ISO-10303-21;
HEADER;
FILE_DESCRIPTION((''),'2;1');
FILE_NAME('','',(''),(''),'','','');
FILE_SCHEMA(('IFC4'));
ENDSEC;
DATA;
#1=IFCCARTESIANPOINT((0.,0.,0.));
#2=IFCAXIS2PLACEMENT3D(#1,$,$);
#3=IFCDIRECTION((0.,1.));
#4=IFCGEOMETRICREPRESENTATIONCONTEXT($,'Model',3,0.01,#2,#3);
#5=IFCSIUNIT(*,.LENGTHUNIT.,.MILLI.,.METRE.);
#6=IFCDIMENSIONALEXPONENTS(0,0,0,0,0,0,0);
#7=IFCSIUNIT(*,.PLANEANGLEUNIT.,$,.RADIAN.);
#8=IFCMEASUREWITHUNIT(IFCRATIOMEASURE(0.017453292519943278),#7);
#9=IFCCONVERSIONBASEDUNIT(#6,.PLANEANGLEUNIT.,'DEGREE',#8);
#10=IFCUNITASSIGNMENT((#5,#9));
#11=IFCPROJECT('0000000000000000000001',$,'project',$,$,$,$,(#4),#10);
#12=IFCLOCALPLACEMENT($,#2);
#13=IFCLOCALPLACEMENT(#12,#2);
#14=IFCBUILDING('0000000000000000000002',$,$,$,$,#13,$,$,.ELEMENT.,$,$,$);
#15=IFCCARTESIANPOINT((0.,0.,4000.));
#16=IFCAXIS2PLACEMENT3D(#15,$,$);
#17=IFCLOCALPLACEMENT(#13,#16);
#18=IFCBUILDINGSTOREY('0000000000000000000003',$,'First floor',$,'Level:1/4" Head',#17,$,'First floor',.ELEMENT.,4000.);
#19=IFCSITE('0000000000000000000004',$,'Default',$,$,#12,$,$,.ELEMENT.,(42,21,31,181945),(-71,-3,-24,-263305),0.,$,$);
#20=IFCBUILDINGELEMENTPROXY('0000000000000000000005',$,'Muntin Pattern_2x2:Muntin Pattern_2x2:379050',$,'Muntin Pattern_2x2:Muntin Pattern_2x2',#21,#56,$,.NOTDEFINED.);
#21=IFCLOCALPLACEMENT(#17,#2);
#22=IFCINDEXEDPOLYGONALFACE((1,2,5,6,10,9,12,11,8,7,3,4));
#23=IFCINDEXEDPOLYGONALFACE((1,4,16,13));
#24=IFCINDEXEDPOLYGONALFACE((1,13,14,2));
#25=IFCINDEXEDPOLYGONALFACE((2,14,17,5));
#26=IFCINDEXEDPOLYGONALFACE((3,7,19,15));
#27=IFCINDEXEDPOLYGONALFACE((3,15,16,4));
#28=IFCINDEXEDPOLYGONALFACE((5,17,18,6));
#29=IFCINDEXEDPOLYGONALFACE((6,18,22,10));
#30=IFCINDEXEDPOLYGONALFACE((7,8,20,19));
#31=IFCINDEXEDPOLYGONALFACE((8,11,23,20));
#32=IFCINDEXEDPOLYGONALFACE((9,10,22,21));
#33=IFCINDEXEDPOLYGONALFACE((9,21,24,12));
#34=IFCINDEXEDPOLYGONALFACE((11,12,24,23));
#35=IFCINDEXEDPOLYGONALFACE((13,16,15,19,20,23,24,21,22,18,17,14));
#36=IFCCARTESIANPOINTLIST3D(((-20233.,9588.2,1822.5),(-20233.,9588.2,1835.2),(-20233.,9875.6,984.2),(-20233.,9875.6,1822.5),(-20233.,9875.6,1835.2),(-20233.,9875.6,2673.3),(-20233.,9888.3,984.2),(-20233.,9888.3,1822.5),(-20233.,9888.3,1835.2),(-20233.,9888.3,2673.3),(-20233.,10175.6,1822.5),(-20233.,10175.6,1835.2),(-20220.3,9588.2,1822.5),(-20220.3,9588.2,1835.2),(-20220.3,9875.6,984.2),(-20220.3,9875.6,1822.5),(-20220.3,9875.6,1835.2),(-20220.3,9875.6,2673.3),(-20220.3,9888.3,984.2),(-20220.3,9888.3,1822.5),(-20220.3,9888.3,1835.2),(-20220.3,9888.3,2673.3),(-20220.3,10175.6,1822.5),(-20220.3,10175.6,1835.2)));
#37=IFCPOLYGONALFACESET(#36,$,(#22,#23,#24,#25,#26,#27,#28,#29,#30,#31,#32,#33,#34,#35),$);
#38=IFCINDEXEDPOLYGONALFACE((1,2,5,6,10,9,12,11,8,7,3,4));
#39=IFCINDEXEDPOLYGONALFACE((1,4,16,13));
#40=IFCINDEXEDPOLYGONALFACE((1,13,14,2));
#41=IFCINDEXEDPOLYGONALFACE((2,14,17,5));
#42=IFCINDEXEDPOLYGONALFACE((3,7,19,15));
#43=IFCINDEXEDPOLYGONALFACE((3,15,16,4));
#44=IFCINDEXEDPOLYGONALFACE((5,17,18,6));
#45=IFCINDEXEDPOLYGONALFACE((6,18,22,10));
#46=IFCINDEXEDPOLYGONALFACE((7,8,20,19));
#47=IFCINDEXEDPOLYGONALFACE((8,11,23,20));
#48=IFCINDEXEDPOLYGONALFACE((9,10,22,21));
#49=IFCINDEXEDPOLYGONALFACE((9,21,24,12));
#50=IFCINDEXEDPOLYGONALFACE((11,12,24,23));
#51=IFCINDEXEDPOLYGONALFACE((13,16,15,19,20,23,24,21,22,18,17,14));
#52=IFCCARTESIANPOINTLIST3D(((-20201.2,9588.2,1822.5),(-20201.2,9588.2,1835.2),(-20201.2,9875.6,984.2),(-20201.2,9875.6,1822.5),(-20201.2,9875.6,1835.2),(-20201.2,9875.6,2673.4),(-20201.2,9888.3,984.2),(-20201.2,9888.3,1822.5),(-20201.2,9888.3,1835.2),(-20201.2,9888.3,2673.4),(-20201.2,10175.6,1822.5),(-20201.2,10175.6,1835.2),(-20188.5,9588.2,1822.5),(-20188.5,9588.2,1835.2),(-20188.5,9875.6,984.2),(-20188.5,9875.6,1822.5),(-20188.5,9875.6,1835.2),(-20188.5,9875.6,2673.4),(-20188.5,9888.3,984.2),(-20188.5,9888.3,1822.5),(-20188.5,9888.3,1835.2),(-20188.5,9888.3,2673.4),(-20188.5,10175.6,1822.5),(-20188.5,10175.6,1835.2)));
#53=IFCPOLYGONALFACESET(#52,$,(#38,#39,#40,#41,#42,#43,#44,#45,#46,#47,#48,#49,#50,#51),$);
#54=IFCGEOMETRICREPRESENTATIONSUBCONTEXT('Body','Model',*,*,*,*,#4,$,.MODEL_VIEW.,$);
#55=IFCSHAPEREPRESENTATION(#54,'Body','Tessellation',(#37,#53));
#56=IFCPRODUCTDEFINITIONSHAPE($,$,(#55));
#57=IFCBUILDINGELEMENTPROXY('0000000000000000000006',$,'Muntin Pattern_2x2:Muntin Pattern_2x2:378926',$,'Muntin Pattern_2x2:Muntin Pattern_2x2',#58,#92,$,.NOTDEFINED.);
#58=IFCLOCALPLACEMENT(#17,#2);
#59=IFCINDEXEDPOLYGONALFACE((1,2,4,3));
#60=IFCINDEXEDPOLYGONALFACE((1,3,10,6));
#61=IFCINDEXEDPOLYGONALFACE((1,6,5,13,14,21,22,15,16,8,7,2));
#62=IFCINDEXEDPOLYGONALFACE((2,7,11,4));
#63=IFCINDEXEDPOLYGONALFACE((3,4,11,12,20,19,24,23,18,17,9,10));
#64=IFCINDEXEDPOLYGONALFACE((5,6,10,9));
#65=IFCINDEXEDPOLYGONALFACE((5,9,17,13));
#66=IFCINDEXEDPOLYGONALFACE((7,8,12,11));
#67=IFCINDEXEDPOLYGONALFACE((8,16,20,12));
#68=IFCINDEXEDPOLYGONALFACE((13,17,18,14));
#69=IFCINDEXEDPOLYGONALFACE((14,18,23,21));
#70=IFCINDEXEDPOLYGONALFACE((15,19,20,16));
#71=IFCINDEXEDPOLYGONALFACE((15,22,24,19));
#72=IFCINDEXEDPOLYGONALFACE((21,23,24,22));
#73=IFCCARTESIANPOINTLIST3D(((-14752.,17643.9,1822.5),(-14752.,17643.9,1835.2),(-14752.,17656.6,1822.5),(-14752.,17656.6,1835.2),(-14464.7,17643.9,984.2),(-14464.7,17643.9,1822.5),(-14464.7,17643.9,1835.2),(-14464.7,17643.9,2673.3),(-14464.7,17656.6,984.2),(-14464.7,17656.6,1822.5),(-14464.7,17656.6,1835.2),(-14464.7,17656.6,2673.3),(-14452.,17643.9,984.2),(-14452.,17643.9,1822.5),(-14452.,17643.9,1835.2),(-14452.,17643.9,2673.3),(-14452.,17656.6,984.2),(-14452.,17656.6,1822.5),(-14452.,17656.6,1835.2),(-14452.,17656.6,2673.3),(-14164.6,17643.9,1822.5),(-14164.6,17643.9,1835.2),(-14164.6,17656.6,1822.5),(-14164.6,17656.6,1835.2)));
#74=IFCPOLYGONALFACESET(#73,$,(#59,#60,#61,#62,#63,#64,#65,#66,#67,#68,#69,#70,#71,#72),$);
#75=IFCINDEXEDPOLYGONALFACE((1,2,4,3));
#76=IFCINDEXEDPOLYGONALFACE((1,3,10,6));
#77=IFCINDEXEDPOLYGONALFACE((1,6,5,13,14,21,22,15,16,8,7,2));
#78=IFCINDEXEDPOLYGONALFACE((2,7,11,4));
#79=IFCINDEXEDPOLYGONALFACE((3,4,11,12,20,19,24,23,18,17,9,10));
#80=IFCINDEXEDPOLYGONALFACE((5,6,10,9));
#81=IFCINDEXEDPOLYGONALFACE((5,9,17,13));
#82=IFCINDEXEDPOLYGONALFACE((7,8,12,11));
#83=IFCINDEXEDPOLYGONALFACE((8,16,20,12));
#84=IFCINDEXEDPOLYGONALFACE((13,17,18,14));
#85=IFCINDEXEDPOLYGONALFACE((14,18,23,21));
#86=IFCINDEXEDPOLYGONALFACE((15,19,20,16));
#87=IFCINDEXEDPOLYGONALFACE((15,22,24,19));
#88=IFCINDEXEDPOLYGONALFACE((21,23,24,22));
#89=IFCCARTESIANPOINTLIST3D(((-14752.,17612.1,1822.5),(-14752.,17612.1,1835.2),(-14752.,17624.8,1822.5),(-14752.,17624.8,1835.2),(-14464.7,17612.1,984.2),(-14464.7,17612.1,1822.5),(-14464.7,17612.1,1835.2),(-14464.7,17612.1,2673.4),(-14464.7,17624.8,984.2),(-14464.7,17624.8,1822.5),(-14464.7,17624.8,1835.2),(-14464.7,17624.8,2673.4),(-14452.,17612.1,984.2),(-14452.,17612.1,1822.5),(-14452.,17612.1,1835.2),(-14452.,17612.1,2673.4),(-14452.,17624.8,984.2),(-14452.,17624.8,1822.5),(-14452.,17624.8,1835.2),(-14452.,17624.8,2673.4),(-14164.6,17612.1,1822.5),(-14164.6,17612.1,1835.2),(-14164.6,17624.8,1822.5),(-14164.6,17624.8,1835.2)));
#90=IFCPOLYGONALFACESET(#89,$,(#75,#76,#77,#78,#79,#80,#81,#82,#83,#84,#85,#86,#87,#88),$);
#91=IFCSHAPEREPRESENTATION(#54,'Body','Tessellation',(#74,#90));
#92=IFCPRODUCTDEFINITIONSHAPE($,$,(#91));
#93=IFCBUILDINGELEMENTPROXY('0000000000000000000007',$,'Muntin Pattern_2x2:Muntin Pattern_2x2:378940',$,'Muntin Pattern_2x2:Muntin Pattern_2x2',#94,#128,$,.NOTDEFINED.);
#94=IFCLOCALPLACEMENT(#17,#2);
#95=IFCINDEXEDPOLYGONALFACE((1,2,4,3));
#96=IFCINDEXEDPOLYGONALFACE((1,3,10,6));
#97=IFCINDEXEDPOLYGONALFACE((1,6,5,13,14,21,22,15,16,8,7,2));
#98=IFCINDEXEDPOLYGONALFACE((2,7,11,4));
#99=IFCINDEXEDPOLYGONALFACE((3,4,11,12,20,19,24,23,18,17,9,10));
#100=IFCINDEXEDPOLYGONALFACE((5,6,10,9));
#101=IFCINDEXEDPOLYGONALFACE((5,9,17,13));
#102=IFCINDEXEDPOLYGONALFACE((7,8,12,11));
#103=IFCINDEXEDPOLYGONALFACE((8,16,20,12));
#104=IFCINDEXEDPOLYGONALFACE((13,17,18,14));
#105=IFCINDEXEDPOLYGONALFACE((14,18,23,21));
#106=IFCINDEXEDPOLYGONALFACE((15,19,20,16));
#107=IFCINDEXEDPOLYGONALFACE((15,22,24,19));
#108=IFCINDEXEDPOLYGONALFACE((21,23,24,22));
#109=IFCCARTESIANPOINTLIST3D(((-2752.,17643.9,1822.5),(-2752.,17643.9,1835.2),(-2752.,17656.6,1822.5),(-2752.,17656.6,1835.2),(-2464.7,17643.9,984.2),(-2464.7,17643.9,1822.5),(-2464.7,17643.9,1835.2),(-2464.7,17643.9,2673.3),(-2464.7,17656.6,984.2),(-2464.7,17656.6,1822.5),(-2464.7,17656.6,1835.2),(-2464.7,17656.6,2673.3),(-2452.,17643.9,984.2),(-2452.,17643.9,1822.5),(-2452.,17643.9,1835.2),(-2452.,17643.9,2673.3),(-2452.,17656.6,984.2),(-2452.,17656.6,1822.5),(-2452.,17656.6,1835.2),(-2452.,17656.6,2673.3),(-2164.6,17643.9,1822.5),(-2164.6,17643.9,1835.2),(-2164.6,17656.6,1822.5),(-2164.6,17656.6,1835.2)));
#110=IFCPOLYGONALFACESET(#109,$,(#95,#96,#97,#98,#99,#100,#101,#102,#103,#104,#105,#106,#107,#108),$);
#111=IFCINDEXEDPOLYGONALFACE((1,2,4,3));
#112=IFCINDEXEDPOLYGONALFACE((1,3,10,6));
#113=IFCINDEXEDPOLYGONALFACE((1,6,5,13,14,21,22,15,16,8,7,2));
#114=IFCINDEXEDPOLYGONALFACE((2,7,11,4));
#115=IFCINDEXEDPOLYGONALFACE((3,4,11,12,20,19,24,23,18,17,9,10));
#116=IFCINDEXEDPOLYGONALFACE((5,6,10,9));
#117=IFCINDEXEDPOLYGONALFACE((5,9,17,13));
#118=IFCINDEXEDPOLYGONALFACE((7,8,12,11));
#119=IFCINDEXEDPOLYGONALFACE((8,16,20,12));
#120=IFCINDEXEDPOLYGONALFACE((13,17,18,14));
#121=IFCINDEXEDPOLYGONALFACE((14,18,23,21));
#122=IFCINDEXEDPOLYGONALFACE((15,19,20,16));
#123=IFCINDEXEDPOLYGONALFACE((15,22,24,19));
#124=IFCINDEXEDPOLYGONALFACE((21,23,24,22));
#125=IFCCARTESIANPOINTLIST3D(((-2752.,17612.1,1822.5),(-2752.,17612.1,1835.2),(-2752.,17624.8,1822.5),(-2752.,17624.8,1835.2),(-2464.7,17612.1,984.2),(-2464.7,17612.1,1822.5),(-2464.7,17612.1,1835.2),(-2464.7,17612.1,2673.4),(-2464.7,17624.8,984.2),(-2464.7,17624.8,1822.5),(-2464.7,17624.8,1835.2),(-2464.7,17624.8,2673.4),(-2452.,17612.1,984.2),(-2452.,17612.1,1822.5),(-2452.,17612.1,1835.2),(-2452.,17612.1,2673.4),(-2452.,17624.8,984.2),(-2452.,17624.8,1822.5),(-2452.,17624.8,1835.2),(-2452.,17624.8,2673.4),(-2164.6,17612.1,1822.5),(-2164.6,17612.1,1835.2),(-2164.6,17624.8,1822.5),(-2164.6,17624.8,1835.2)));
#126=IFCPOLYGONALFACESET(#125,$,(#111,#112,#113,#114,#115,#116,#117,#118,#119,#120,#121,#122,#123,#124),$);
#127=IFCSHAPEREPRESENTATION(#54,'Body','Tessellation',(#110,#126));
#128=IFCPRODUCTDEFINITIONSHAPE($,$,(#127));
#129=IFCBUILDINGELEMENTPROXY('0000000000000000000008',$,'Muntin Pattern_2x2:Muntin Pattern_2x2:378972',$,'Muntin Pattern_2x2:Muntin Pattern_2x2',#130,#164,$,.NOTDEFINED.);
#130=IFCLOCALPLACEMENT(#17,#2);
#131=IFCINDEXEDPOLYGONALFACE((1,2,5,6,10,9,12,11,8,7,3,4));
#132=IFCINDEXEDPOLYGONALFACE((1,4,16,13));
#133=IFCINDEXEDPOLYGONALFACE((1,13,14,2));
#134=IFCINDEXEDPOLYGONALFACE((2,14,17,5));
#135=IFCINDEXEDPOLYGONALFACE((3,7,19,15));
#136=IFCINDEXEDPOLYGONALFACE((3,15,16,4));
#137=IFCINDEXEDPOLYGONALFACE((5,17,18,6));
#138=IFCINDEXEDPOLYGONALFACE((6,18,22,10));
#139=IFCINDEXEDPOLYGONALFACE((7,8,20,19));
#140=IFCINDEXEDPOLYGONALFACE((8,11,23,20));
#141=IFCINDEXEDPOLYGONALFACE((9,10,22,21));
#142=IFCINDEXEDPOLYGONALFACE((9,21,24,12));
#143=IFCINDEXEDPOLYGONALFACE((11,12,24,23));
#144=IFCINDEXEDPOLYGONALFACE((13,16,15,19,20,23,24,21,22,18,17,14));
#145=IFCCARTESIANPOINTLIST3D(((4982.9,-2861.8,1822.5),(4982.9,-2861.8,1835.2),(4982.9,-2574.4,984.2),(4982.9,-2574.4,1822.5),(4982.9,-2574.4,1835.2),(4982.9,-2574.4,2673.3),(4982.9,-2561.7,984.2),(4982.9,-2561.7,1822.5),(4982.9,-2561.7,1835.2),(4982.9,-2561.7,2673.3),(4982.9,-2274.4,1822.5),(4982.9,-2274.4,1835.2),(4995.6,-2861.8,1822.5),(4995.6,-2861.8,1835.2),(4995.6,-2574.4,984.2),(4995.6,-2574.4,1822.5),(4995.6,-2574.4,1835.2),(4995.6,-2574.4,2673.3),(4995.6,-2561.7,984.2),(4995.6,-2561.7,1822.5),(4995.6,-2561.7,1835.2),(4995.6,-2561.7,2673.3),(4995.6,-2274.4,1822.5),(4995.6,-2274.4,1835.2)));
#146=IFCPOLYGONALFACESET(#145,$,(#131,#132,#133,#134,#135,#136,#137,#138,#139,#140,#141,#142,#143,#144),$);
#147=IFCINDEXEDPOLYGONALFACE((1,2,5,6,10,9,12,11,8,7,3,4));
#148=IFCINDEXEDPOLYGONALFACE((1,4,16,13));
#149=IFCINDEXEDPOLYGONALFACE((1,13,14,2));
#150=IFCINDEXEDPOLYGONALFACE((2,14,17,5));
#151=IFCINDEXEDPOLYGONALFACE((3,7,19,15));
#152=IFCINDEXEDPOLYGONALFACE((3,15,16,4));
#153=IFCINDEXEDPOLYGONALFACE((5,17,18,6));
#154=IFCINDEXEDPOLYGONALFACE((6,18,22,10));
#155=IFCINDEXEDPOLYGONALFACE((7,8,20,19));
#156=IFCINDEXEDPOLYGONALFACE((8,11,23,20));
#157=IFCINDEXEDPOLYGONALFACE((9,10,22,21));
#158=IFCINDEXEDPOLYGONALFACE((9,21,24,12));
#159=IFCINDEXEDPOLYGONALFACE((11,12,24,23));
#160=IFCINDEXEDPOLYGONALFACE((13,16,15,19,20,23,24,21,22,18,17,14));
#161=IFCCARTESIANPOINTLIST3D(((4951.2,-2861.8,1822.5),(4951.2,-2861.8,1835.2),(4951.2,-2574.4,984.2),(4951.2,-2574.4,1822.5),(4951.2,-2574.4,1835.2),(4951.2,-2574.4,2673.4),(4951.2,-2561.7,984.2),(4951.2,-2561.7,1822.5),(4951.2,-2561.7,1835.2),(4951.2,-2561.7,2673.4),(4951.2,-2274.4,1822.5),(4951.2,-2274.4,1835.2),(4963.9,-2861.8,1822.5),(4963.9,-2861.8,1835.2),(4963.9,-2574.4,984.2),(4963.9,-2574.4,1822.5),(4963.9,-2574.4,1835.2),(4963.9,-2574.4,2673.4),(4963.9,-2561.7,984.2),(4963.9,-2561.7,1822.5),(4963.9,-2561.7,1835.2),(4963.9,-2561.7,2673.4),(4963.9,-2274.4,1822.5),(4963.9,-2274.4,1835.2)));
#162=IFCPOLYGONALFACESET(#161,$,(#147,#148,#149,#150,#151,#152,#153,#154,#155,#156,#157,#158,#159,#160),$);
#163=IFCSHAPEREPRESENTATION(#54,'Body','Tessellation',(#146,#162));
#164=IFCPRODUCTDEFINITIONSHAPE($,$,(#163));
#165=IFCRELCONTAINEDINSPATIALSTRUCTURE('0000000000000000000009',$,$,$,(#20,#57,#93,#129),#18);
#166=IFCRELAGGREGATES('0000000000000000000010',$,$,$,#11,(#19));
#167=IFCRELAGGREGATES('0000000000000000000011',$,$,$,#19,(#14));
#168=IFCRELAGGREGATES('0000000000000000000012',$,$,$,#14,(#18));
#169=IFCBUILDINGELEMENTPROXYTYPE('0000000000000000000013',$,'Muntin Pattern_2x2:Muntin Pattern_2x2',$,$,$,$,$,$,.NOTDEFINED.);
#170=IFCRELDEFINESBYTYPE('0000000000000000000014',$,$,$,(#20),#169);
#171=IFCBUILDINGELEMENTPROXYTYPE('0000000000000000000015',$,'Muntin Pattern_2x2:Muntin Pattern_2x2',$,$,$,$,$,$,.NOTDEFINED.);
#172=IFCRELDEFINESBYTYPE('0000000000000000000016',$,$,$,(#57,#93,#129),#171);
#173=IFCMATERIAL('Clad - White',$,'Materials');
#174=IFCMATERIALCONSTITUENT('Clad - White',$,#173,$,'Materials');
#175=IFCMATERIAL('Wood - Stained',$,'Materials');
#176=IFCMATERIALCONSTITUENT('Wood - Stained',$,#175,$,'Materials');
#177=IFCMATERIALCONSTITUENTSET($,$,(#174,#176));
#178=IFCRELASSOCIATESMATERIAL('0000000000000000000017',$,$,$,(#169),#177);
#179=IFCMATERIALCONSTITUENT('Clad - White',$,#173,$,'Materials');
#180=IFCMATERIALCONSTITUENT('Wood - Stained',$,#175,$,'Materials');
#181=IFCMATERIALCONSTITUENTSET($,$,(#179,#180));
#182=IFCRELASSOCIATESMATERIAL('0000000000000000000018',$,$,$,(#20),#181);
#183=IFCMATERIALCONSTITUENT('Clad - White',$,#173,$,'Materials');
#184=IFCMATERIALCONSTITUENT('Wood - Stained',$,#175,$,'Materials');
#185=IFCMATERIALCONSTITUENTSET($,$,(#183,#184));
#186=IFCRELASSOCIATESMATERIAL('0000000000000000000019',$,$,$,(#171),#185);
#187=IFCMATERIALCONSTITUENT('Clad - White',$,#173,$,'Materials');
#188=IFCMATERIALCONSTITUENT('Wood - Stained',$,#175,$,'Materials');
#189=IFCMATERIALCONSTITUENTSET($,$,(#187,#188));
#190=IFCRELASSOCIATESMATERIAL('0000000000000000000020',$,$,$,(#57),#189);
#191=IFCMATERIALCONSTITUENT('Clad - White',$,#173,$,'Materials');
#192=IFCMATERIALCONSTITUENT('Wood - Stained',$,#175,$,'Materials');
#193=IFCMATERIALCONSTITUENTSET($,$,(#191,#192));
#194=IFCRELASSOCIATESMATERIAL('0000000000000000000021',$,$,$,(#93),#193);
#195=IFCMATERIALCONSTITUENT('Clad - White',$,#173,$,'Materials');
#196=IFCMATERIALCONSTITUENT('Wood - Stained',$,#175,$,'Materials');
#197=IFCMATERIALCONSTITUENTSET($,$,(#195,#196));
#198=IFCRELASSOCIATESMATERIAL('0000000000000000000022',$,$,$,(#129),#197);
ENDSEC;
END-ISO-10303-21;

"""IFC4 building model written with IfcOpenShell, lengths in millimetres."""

from ifc_helpers import new_model, entity, si_unit, converted_unit, direction, frame, origin, place, context, subcontext, project, spatial, indexed_curve, outline, extrude, source, transform, mapped, material, constituent, constituent_set, type_object, type_shapes, element, save


model = new_model("IFC4")

# Units and contexts
model_context = context("Model", 3, precision=0.01, world=origin(), true_north=direction((0.0, 1.0)))
body_context = subcontext(model_context, "Body", "Model", "MODEL_VIEW")
ifc_project = project(units=[si_unit("LENGTHUNIT", "METRE", prefix="MILLI"), converted_unit("PLANEANGLEUNIT", "DEGREE", entity("IfcRatioMeasure", 0.017453292519943278), si_unit("PLANEANGLEUNIT", "RADIAN"), dimensions=[0, 0, 0, 0, 0, 0, 0])], contexts=[model_context])

# Site, building, storey
site_placement = place(None, origin())
site = spatial("IfcSite", under=ifc_project, at=site_placement, Name="Default", CompositionType="ELEMENT", RefLatitude=(42, 21, 31, 181945), RefLongitude=(-71, -3, -24, -263305), RefElevation=0.0)
building_placement = place(site_placement, origin())
building = spatial("IfcBuilding", under=site, at=building_placement, CompositionType="ELEMENT")
storey_placement = place(building_placement, frame((0.0, 0.0, 4000.0)))
storey = spatial("IfcBuildingStorey", under=building, at=storey_placement, Name="First floor", ObjectType="Level:1/4\" Head", LongName="First floor", CompositionType="ELEMENT", Elevation=4000.0)

# Building element proxies
ifc_material_1 = material(Name="Clad - White", Category="Materials")
ifc_material_2 = material(Name="Wood - Stained", Category="Materials")
ifc_constituent_1 = constituent(ifc_material_1, Name="Clad - White", Category="Materials")
ifc_constituent_2 = constituent(ifc_material_2, Name="Wood - Stained", Category="Materials")
ifc_constituent_set_1 = constituent_set(constituents=[ifc_constituent_1, ifc_constituent_2])
building_element_proxy_type_1 = type_object("IfcBuildingElementProxyType", Name="Muntin Pattern_2x2:Muntin Pattern_2x2", PredefinedType="NOTDEFINED", material=ifc_constituent_set_1)
shared_shape_1 = source(origin(), body_context, "Body", "SweptSolid", [
    extrude(outline(indexed_curve([(6.4, -6.4), (844.5, -6.4), (844.5, 6.3), (6.4, 6.3), (6.4, 293.7), (-6.3, 293.7), (-6.3, 6.3), (-844.6, 6.3), (-844.6, -6.4), (-6.3, -6.4), (-6.3, -293.7), (6.4, -293.7), (6.4, -6.4)], self_intersect=False)), frame((0.0, 9.5, 844.5), z_axis=(0.0, 1.0, 0.0), x_axis=(0.0, 0.0, 1.0)), (0.0, 0.0, 1.0), 12.7),
    extrude(outline(indexed_curve([(6.4, -6.4), (844.6, -6.4), (844.6, 6.3), (6.4, 6.3), (6.4, 293.7), (-6.3, 293.7), (-6.3, 6.3), (-844.6, 6.3), (-844.6, -6.4), (-6.3, -6.4), (-6.3, -293.7), (6.4, -293.7), (6.4, -6.4)], self_intersect=False)), frame((0.0, -22.2, 844.6), z_axis=(0.0, 1.0, 0.0), x_axis=(0.0, 0.0, 1.0)), (0.0, 0.0, 1.0), 12.7),
])
type_shapes(building_element_proxy_type_1, [shared_shape_1])
ifc_constituent_3 = constituent(ifc_material_1, Name="Clad - White", Category="Materials")
ifc_constituent_4 = constituent(ifc_material_2, Name="Wood - Stained", Category="Materials")
ifc_constituent_set_2 = constituent_set(constituents=[ifc_constituent_3, ifc_constituent_4])
proxy_1_placement = place(storey_placement, frame((-20210.8, 9881.9, 984.3), z_axis=(0.0, 0.0, 1.0), x_axis=(0.0, 1.0, 0.0)))
element("IfcBuildingElementProxy", 1, at=proxy_1_placement, inside=storey, type_object=building_element_proxy_type_1, material=ifc_constituent_set_2, Name="Muntin Pattern_2x2:Muntin Pattern_2x2:379050", ObjectType="Muntin Pattern_2x2:Muntin Pattern_2x2", PredefinedType="NOTDEFINED", context=body_context, shape_type="MappedRepresentation", body=[
    mapped(shared_shape_1, transform((0.0, 0.0, 0.0), scale=1.0)),
])
ifc_constituent_5 = constituent(ifc_material_1, Name="Clad - White", Category="Materials")
ifc_constituent_6 = constituent(ifc_material_2, Name="Wood - Stained", Category="Materials")
ifc_constituent_set_3 = constituent_set(constituents=[ifc_constituent_5, ifc_constituent_6])
ifc_constituent_7 = constituent(ifc_material_1, Name="Clad - White", Category="Materials")
ifc_constituent_8 = constituent(ifc_material_2, Name="Wood - Stained", Category="Materials")
ifc_constituent_set_4 = constituent_set(constituents=[ifc_constituent_7, ifc_constituent_8])
building_element_proxy_type_2 = type_object("IfcBuildingElementProxyType", Name="Muntin Pattern_2x2:Muntin Pattern_2x2", PredefinedType="NOTDEFINED", material=ifc_constituent_set_4)
shared_shape_2 = source(origin(), body_context, "Body", "SweptSolid", [
    extrude(outline(indexed_curve([(6.4, -6.4), (844.5, -6.4), (844.5, 6.3), (6.4, 6.3), (6.4, 293.7), (-6.3, 293.7), (-6.3, 6.3), (-844.6, 6.3), (-844.6, -6.4), (-6.3, -6.4), (-6.3, -293.7), (6.4, -293.7), (6.4, -6.4)], self_intersect=False)), frame((0.0, -22.2, 844.5), z_axis=(0.0, 1.0, 0.0), x_axis=(0.0, 0.0, 1.0)), (0.0, 0.0, 1.0), 12.7),
    extrude(outline(indexed_curve([(6.4, -6.4), (844.6, -6.4), (844.6, 6.3), (6.4, 6.3), (6.4, 293.7), (-6.3, 293.7), (-6.3, 6.3), (-844.6, 6.3), (-844.6, -6.4), (-6.3, -6.4), (-6.3, -293.7), (6.4, -293.7), (6.4, -6.4)], self_intersect=False)), frame((0.0, 9.5, 844.6), z_axis=(0.0, 1.0, 0.0), x_axis=(0.0, 0.0, 1.0)), (0.0, 0.0, 1.0), 12.7),
])
type_shapes(building_element_proxy_type_2, [shared_shape_2])
proxy_2_placement = place(storey_placement, frame((-14458.3, 17634.3, 984.3), z_axis=(0.0, 0.0, 1.0), x_axis=(-1.0, 0.0, 0.0)))
element("IfcBuildingElementProxy", 2, at=proxy_2_placement, inside=storey, type_object=building_element_proxy_type_2, material=ifc_constituent_set_3, Name="Muntin Pattern_2x2:Muntin Pattern_2x2:378926", ObjectType="Muntin Pattern_2x2:Muntin Pattern_2x2", PredefinedType="NOTDEFINED", context=body_context, shape_type="MappedRepresentation", body=[
    mapped(shared_shape_2, transform((0.0, 0.0, 0.0), scale=1.0)),
])
ifc_constituent_9 = constituent(ifc_material_1, Name="Clad - White", Category="Materials")
ifc_constituent_10 = constituent(ifc_material_2, Name="Wood - Stained", Category="Materials")
ifc_constituent_set_5 = constituent_set(constituents=[ifc_constituent_9, ifc_constituent_10])
proxy_3_placement = place(storey_placement, frame((-2458.3, 17634.3, 984.3), z_axis=(0.0, 0.0, 1.0), x_axis=(-1.0, 0.0, 0.0)))
element("IfcBuildingElementProxy", 3, at=proxy_3_placement, inside=storey, type_object=building_element_proxy_type_2, material=ifc_constituent_set_5, Name="Muntin Pattern_2x2:Muntin Pattern_2x2:378940", ObjectType="Muntin Pattern_2x2:Muntin Pattern_2x2", PredefinedType="NOTDEFINED", context=body_context, shape_type="MappedRepresentation", body=[
    mapped(shared_shape_2, transform((0.0, 0.0, 0.0), scale=1.0)),
])
ifc_constituent_11 = constituent(ifc_material_1, Name="Clad - White", Category="Materials")
ifc_constituent_12 = constituent(ifc_material_2, Name="Wood - Stained", Category="Materials")
ifc_constituent_set_6 = constituent_set(constituents=[ifc_constituent_11, ifc_constituent_12])
proxy_4_placement = place(storey_placement, frame((4973.4, -2568.1, 984.3), z_axis=(0.0, 0.0, 1.0), x_axis=(0.0, 1.0, 0.0)))
element("IfcBuildingElementProxy", 4, at=proxy_4_placement, inside=storey, type_object=building_element_proxy_type_2, material=ifc_constituent_set_6, Name="Muntin Pattern_2x2:Muntin Pattern_2x2:378972", ObjectType="Muntin Pattern_2x2:Muntin Pattern_2x2", PredefinedType="NOTDEFINED", context=body_context, shape_type="MappedRepresentation", body=[
    mapped(shared_shape_2, transform((0.0, 0.0, 0.0), scale=1.0)),
])

save(model, "model.ifc")
